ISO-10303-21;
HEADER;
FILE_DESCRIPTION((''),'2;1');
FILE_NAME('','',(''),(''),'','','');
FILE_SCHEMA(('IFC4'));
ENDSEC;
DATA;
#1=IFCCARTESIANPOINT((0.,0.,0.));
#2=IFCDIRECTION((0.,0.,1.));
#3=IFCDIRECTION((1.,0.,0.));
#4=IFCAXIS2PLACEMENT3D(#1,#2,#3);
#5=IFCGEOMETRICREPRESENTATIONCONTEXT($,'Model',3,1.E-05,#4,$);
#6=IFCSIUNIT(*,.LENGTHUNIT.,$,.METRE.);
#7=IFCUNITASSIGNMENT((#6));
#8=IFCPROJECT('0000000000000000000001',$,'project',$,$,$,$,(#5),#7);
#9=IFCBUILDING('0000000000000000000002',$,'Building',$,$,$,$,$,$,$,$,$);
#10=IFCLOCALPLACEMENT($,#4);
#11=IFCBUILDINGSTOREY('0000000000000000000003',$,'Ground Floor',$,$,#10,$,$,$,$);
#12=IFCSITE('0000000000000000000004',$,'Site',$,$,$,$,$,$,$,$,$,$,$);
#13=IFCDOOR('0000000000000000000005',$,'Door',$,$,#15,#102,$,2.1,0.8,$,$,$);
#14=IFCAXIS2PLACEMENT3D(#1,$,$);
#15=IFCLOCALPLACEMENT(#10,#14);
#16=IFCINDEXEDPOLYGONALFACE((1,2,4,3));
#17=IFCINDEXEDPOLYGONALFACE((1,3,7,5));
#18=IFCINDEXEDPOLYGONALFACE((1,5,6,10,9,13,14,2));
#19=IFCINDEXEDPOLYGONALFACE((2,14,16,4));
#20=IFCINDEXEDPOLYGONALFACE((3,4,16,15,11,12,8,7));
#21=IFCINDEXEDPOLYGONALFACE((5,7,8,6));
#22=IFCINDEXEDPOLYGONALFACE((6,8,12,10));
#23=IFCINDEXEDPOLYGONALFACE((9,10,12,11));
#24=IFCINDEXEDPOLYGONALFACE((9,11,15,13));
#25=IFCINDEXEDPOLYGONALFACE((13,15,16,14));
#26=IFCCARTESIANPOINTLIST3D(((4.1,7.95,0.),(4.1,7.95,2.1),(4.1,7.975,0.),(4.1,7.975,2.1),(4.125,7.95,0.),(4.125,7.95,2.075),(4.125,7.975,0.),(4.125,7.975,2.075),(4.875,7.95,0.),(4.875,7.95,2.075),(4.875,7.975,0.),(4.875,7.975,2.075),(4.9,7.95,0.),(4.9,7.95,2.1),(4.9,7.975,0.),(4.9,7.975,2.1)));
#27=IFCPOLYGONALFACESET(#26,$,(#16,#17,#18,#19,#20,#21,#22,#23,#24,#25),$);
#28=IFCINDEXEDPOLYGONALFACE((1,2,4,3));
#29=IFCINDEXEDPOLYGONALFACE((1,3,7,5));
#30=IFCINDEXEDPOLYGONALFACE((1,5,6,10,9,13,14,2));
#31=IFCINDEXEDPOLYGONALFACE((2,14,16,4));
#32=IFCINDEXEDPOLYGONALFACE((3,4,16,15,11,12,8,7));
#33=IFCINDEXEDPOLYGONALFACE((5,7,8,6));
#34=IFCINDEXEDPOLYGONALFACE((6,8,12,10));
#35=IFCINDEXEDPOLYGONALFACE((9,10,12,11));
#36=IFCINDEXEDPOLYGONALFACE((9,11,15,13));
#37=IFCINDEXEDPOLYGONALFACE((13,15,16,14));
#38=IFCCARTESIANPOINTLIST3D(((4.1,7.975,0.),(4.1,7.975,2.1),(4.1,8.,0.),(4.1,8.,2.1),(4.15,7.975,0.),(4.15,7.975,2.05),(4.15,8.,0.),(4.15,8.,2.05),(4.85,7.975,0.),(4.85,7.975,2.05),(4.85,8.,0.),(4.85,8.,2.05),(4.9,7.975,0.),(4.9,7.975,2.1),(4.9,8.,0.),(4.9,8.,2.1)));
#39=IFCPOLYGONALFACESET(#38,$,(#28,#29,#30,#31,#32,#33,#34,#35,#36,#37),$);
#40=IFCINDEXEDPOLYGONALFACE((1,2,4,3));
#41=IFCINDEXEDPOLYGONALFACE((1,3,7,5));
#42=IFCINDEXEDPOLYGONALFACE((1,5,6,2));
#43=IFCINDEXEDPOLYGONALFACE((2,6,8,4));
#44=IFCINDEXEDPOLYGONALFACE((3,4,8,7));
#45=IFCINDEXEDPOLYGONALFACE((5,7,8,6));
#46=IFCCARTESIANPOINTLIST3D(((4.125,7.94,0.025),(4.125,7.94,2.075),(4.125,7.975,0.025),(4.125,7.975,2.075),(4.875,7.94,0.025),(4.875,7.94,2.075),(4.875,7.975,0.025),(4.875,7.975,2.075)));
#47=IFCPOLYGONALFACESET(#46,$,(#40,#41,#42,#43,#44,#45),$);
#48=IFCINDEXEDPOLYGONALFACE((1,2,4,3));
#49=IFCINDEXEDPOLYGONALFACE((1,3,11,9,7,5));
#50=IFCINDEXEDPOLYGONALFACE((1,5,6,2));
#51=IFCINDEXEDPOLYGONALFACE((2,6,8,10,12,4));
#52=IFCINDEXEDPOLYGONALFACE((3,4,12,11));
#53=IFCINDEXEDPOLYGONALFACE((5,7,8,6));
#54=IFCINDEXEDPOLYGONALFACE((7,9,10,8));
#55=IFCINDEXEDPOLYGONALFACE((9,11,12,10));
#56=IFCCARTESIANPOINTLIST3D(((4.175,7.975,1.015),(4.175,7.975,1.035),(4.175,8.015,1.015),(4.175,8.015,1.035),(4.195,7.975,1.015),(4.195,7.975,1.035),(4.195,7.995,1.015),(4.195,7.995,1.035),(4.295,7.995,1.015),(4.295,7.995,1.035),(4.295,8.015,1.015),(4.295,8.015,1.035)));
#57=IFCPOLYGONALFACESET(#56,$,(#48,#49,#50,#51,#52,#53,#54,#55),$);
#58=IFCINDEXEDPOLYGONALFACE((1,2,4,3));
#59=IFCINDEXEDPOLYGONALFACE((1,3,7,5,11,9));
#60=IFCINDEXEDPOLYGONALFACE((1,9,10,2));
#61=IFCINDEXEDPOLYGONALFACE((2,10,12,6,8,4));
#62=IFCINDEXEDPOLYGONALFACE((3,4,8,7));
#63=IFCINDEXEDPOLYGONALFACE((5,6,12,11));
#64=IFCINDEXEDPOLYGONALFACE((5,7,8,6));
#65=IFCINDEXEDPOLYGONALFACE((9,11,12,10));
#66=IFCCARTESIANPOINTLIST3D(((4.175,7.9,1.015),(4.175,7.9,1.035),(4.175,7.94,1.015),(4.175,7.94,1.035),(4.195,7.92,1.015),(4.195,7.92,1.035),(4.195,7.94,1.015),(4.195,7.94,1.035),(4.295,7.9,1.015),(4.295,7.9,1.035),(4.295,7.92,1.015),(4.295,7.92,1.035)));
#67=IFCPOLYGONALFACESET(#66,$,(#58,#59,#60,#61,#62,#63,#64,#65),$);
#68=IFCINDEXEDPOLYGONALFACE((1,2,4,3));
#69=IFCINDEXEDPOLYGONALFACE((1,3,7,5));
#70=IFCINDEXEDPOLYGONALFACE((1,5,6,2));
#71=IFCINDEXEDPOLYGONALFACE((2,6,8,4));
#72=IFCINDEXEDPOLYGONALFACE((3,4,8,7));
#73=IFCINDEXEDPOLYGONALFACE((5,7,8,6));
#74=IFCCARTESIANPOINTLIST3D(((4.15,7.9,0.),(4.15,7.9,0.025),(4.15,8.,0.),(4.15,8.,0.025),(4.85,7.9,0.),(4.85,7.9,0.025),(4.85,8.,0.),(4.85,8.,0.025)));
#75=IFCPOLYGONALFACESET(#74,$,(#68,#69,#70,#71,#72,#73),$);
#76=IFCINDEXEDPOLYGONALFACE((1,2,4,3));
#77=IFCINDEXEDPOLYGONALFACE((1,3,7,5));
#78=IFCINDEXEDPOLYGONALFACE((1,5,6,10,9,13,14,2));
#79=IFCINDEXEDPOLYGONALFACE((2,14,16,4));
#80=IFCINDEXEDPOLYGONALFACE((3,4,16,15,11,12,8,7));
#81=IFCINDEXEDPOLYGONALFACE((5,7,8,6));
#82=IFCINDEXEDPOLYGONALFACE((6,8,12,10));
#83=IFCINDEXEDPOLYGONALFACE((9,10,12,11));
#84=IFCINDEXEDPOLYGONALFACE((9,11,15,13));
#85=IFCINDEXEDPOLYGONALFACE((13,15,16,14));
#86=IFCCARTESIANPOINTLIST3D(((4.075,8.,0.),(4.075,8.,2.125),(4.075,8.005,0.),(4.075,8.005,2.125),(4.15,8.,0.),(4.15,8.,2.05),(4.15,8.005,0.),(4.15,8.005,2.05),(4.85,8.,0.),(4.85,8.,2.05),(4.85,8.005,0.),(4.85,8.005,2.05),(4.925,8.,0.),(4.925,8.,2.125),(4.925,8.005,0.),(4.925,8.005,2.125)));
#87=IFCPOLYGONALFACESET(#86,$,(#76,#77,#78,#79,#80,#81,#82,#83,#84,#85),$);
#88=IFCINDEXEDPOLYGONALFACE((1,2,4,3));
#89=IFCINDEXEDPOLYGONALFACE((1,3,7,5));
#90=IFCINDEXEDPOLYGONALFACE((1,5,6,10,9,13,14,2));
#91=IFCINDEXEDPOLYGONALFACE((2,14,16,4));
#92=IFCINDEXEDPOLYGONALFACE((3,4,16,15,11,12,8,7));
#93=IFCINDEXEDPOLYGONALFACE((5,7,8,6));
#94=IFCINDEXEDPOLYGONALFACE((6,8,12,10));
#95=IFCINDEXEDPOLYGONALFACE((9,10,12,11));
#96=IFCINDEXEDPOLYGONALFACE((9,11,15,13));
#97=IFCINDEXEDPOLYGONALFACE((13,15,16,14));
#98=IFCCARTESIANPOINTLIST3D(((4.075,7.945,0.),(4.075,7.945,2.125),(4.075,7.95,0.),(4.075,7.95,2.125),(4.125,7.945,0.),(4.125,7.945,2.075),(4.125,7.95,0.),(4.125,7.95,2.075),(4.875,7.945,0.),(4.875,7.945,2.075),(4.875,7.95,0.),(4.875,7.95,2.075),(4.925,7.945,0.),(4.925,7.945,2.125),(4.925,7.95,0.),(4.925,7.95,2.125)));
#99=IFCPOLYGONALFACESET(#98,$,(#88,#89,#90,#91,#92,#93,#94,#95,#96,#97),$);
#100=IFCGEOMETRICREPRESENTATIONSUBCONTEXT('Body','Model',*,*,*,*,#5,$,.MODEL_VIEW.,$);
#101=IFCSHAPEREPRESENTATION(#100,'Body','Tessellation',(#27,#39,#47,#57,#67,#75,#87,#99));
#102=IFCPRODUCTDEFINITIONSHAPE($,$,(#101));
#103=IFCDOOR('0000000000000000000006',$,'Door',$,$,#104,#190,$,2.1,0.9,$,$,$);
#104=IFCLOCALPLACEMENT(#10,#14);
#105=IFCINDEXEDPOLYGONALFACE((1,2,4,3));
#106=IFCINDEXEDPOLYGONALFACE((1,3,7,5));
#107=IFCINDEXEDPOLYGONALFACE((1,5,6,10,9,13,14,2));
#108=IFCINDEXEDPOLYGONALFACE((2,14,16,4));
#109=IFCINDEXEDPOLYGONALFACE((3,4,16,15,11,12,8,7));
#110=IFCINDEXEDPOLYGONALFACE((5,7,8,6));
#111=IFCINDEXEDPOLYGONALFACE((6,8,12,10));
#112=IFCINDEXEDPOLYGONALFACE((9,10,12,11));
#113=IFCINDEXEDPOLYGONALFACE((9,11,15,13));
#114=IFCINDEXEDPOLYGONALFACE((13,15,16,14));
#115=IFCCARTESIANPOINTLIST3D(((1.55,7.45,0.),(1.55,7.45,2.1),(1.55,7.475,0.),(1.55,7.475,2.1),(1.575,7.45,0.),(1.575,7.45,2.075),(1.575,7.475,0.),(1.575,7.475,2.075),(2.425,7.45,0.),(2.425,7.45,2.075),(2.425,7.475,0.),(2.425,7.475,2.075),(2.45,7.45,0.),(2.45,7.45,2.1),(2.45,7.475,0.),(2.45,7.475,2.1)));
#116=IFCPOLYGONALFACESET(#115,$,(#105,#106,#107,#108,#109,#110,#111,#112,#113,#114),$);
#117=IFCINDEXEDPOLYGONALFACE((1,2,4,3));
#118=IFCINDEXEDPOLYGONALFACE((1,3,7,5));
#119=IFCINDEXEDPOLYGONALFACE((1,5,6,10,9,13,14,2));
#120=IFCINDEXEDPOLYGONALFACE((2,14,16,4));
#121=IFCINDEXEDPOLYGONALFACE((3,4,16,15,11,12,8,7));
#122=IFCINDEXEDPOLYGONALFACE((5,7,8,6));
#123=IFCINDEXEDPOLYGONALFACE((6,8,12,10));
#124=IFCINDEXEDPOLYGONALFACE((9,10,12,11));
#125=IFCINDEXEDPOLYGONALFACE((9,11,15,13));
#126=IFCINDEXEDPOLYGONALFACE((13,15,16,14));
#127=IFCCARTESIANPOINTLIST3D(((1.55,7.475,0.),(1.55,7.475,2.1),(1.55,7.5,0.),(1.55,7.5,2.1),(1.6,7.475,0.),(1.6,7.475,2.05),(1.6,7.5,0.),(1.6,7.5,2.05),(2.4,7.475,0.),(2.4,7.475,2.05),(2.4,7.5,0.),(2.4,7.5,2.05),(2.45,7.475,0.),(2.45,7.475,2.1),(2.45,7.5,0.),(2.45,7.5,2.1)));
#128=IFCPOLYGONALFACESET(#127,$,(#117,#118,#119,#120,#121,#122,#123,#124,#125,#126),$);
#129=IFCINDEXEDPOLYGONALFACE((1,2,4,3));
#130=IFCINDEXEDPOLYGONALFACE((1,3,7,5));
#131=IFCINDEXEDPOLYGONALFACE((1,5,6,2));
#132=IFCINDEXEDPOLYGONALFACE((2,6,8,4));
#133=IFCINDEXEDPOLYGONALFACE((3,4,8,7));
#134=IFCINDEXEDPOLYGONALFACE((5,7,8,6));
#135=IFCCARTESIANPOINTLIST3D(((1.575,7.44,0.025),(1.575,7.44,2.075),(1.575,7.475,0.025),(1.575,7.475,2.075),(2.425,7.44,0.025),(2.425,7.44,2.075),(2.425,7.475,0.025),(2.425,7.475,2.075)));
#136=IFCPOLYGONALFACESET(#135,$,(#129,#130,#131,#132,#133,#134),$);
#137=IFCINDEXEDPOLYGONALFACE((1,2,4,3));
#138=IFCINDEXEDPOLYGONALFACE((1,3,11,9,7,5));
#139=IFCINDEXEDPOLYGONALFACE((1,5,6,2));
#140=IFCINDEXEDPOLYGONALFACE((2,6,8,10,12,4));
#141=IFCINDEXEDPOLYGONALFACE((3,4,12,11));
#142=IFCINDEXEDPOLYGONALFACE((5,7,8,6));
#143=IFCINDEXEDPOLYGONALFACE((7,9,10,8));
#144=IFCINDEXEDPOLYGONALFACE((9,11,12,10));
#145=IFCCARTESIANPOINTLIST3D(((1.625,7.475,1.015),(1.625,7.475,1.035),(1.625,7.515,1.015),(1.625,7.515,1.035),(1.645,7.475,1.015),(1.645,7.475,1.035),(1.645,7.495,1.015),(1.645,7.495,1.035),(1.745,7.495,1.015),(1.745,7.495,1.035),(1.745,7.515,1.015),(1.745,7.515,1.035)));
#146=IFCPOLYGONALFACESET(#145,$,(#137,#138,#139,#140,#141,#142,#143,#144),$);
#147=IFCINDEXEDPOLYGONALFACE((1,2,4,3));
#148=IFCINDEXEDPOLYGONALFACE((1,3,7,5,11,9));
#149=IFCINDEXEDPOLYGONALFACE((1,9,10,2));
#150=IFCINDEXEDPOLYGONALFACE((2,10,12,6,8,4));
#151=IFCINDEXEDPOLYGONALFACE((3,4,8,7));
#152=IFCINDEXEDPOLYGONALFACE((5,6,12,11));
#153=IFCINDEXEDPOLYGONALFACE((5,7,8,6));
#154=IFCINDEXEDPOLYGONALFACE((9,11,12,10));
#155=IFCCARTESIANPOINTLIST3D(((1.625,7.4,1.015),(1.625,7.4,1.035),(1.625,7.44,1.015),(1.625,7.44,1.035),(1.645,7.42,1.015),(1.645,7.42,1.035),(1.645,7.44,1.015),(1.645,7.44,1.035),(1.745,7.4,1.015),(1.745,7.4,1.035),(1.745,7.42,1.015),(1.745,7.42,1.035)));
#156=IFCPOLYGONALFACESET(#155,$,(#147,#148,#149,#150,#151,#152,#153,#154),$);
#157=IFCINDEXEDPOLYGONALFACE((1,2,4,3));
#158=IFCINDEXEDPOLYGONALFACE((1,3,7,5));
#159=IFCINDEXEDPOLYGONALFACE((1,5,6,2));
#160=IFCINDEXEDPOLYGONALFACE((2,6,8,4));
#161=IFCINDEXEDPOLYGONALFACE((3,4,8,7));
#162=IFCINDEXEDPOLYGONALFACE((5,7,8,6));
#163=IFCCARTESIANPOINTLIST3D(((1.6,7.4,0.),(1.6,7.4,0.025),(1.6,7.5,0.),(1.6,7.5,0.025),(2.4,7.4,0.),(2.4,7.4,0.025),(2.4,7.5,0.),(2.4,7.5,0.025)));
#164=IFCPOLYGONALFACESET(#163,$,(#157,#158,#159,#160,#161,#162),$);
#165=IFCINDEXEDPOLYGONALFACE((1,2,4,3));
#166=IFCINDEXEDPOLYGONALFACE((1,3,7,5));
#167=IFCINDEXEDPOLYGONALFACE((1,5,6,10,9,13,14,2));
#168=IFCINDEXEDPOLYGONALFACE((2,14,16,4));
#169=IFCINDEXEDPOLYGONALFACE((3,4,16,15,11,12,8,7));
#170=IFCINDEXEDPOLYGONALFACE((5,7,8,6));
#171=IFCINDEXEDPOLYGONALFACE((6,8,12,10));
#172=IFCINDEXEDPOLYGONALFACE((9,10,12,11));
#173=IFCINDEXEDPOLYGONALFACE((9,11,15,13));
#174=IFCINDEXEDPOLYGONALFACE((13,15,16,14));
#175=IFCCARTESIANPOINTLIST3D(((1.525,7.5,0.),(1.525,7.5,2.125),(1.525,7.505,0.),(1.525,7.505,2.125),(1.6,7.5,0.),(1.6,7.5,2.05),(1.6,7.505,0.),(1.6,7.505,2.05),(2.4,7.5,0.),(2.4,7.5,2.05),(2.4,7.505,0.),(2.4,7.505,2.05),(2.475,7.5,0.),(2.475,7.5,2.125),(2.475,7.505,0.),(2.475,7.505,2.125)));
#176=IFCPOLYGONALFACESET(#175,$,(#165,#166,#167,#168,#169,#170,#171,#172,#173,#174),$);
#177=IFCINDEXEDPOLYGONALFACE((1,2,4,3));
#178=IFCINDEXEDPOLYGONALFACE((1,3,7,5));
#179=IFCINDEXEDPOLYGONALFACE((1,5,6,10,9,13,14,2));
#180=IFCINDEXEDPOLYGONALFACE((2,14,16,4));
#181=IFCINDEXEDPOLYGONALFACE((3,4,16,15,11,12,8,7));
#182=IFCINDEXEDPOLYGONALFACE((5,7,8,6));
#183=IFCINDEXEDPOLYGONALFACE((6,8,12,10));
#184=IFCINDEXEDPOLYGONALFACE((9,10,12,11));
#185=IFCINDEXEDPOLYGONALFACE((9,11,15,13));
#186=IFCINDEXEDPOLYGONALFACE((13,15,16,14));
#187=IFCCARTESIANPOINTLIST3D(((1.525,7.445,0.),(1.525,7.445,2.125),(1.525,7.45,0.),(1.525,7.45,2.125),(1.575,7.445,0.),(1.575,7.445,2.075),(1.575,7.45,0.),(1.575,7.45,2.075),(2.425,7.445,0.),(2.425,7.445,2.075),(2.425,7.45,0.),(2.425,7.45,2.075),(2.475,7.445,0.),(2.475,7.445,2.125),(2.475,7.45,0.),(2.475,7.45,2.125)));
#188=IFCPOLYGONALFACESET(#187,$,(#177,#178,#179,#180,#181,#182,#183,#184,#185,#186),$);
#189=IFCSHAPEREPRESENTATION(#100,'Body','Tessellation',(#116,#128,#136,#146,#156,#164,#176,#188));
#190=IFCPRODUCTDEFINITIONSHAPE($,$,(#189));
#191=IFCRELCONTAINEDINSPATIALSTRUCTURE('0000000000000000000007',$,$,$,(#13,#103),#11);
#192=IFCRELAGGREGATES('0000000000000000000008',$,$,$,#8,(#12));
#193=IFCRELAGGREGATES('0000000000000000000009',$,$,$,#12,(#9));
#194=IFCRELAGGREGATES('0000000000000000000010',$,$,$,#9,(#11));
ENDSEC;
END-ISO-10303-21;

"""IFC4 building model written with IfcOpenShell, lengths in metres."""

from ifc_helpers import new_model, si_unit, frame, origin_with_axes, place, context, subcontext, project, spatial, line, indexed_curve, outline, extrude, element, save


model = new_model("IFC4")

# Units and contexts
model_context = context("Model", 3, precision=1e-05, world=origin_with_axes())
body_context = subcontext(model_context, "Body", "Model", "MODEL_VIEW")
ifc_project = project(units=[si_unit("LENGTHUNIT", "METRE")], contexts=[model_context])

# Site, building, storey
site = spatial("IfcSite", under=ifc_project, Name="Site")
building = spatial("IfcBuilding", under=site, Name="Building")
storey_placement = place(None, origin_with_axes())
storey = spatial("IfcBuildingStorey", under=building, at=storey_placement, Name="Ground Floor")

# Doors
door_1_placement = place(storey_placement, frame((4.9, 8.0, 0.0), z_axis=(0.0, 0.0, 1.0), x_axis=(-1.0, 0.0, 0.0)))
element("IfcDoor", 1, at=door_1_placement, inside=storey, Name="Door", OverallHeight=2.1, OverallWidth=0.8, context=body_context, shape_type="SweptSolid", body=[
    extrude(outline(indexed_curve([(0.0, 0.0), (0.0, 2.1), (0.8, 2.1), (0.8, 0.0), (0.775, 0.0), (0.775, 2.075), (0.025, 2.075), (0.025, 0.0)], segments=[line(1, 2, 3, 4, 5, 6, 7, 8, 1)])), frame((0.0, 0.025, 0.0), z_axis=(0.0, -1.0, 0.0), x_axis=(1.0, 0.0, 0.0)), (0.0, 0.0, -1.0), 0.025),
    extrude(outline(indexed_curve([(0.0, 0.0), (0.0, 2.1), (0.8, 2.1), (0.8, 0.0), (0.75, 0.0), (0.75, 2.05), (0.05, 2.05), (0.05, 0.0)], segments=[line(1, 2, 3, 4, 5, 6, 7, 8, 1)])), frame((0.0, 0.0, 0.0), z_axis=(0.0, -1.0, 0.0), x_axis=(1.0, 0.0, 0.0)), (0.0, 0.0, -1.0), 0.025),
    extrude(outline(indexed_curve([(0.0, 0.0), (0.75, 0.0), (0.75, 0.035), (0.0, 0.035)], segments=[line(1, 2, 3, 4, 1)])), frame((0.025, 0.025, 0.025), z_axis=(0.0, 0.0, 1.0), x_axis=(1.0, 0.0, 0.0)), (0.0, 0.0, 1.0), 2.05),
    extrude(outline(indexed_curve([(0.0, 0.0), (0.0, -0.04), (-0.12, -0.04), (-0.12, -0.02), (-0.02, -0.02), (-0.02, 0.0)], segments=[line(1, 2, 3, 4, 5, 6, 1)])), frame((0.725, 0.025, 1.015), z_axis=(0.0, 0.0, 1.0), x_axis=(1.0, 0.0, 0.0)), (0.0, 0.0, 1.0), 0.02),
    extrude(outline(indexed_curve([(0.0, 0.0), (0.0, 0.04), (-0.12, 0.04), (-0.12, 0.02), (-0.02, 0.02), (-0.02, 0.0)], segments=[line(1, 2, 3, 4, 5, 6, 1)])), frame((0.725, 0.06, 1.015), z_axis=(0.0, 0.0, 1.0), x_axis=(1.0, 0.0, 0.0)), (0.0, 0.0, 1.0), 0.02),
    extrude(outline(indexed_curve([(0.0, 0.0), (0.7, 0.0), (0.7, 0.1), (0.0, 0.1)], segments=[line(1, 2, 3, 4, 1)])), frame((0.05, 0.0, 0.0), z_axis=(0.0, 0.0, 1.0), x_axis=(1.0, 0.0, 0.0)), (0.0, 0.0, 1.0), 0.025),
    extrude(outline(indexed_curve([(0.0, 0.0), (0.0, 2.125), (0.85, 2.125), (0.85, 0.0), (0.775, 0.0), (0.775, 2.05), (0.075, 2.05), (0.075, 0.0)], segments=[line(1, 2, 3, 4, 5, 6, 7, 8, 1)])), frame((-0.025, -0.005, 0.0), z_axis=(0.0, -1.0, 0.0), x_axis=(1.0, 0.0, 0.0)), (0.0, 0.0, -1.0), 0.005),
    extrude(outline(indexed_curve([(0.0, 0.0), (0.0, 2.125), (0.85, 2.125), (0.85, 0.0), (0.8, 0.0), (0.8, 2.075), (0.05, 2.075), (0.05, 0.0)], segments=[line(1, 2, 3, 4, 5, 6, 7, 8, 1)])), frame((-0.025, 0.05, 0.0), z_axis=(0.0, -1.0, 0.0), x_axis=(1.0, 0.0, 0.0)), (0.0, 0.0, -1.0), 0.005),
])
door_2_placement = place(storey_placement, frame((2.45, 7.5, 0.0), z_axis=(0.0, 0.0, 1.0), x_axis=(-1.0, 0.0, 0.0)))
element("IfcDoor", 2, at=door_2_placement, inside=storey, Name="Door", OverallHeight=2.1, OverallWidth=0.9, context=body_context, shape_type="SweptSolid", body=[
    extrude(outline(indexed_curve([(0.0, 0.0), (0.0, 2.1), (0.9, 2.1), (0.9, 0.0), (0.875, 0.0), (0.875, 2.075), (0.025, 2.075), (0.025, 0.0)], segments=[line(1, 2, 3, 4, 5, 6, 7, 8, 1)])), frame((0.0, 0.025, 0.0), z_axis=(0.0, -1.0, 0.0), x_axis=(1.0, 0.0, 0.0)), (0.0, 0.0, -1.0), 0.025),
    extrude(outline(indexed_curve([(0.0, 0.0), (0.0, 2.1), (0.9, 2.1), (0.9, 0.0), (0.85, 0.0), (0.85, 2.05), (0.05, 2.05), (0.05, 0.0)], segments=[line(1, 2, 3, 4, 5, 6, 7, 8, 1)])), frame((0.0, 0.0, 0.0), z_axis=(0.0, -1.0, 0.0), x_axis=(1.0, 0.0, 0.0)), (0.0, 0.0, -1.0), 0.025),
    extrude(outline(indexed_curve([(0.0, 0.0), (0.85, 0.0), (0.85, 0.035), (0.0, 0.035)], segments=[line(1, 2, 3, 4, 1)])), frame((0.025, 0.025, 0.025), z_axis=(0.0, 0.0, 1.0), x_axis=(1.0, 0.0, 0.0)), (0.0, 0.0, 1.0), 2.05),
    extrude(outline(indexed_curve([(0.0, 0.0), (0.0, -0.04), (-0.12, -0.04), (-0.12, -0.02), (-0.02, -0.02), (-0.02, 0.0)], segments=[line(1, 2, 3, 4, 5, 6, 1)])), frame((0.825, 0.025, 1.015), z_axis=(0.0, 0.0, 1.0), x_axis=(1.0, 0.0, 0.0)), (0.0, 0.0, 1.0), 0.02),
    extrude(outline(indexed_curve([(0.0, 0.0), (0.0, 0.04), (-0.12, 0.04), (-0.12, 0.02), (-0.02, 0.02), (-0.02, 0.0)], segments=[line(1, 2, 3, 4, 5, 6, 1)])), frame((0.825, 0.06, 1.015), z_axis=(0.0, 0.0, 1.0), x_axis=(1.0, 0.0, 0.0)), (0.0, 0.0, 1.0), 0.02),
    extrude(outline(indexed_curve([(0.0, 0.0), (0.8, 0.0), (0.8, 0.1), (0.0, 0.1)], segments=[line(1, 2, 3, 4, 1)])), frame((0.05, 0.0, 0.0), z_axis=(0.0, 0.0, 1.0), x_axis=(1.0, 0.0, 0.0)), (0.0, 0.0, 1.0), 0.025),
    extrude(outline(indexed_curve([(0.0, 0.0), (0.0, 2.125), (0.95, 2.125), (0.95, 0.0), (0.875, 0.0), (0.875, 2.05), (0.075, 2.05), (0.075, 0.0)], segments=[line(1, 2, 3, 4, 5, 6, 7, 8, 1)])), frame((-0.025, -0.005, 0.0), z_axis=(0.0, -1.0, 0.0), x_axis=(1.0, 0.0, 0.0)), (0.0, 0.0, -1.0), 0.005),
    extrude(outline(indexed_curve([(0.0, 0.0), (0.0, 2.125), (0.95, 2.125), (0.95, 0.0), (0.9, 0.0), (0.9, 2.075), (0.05, 2.075), (0.05, 0.0)], segments=[line(1, 2, 3, 4, 5, 6, 7, 8, 1)])), frame((-0.025, 0.05, 0.0), z_axis=(0.0, -1.0, 0.0), x_axis=(1.0, 0.0, 0.0)), (0.0, 0.0, -1.0), 0.005),
])

save(model, "model.ifc")
